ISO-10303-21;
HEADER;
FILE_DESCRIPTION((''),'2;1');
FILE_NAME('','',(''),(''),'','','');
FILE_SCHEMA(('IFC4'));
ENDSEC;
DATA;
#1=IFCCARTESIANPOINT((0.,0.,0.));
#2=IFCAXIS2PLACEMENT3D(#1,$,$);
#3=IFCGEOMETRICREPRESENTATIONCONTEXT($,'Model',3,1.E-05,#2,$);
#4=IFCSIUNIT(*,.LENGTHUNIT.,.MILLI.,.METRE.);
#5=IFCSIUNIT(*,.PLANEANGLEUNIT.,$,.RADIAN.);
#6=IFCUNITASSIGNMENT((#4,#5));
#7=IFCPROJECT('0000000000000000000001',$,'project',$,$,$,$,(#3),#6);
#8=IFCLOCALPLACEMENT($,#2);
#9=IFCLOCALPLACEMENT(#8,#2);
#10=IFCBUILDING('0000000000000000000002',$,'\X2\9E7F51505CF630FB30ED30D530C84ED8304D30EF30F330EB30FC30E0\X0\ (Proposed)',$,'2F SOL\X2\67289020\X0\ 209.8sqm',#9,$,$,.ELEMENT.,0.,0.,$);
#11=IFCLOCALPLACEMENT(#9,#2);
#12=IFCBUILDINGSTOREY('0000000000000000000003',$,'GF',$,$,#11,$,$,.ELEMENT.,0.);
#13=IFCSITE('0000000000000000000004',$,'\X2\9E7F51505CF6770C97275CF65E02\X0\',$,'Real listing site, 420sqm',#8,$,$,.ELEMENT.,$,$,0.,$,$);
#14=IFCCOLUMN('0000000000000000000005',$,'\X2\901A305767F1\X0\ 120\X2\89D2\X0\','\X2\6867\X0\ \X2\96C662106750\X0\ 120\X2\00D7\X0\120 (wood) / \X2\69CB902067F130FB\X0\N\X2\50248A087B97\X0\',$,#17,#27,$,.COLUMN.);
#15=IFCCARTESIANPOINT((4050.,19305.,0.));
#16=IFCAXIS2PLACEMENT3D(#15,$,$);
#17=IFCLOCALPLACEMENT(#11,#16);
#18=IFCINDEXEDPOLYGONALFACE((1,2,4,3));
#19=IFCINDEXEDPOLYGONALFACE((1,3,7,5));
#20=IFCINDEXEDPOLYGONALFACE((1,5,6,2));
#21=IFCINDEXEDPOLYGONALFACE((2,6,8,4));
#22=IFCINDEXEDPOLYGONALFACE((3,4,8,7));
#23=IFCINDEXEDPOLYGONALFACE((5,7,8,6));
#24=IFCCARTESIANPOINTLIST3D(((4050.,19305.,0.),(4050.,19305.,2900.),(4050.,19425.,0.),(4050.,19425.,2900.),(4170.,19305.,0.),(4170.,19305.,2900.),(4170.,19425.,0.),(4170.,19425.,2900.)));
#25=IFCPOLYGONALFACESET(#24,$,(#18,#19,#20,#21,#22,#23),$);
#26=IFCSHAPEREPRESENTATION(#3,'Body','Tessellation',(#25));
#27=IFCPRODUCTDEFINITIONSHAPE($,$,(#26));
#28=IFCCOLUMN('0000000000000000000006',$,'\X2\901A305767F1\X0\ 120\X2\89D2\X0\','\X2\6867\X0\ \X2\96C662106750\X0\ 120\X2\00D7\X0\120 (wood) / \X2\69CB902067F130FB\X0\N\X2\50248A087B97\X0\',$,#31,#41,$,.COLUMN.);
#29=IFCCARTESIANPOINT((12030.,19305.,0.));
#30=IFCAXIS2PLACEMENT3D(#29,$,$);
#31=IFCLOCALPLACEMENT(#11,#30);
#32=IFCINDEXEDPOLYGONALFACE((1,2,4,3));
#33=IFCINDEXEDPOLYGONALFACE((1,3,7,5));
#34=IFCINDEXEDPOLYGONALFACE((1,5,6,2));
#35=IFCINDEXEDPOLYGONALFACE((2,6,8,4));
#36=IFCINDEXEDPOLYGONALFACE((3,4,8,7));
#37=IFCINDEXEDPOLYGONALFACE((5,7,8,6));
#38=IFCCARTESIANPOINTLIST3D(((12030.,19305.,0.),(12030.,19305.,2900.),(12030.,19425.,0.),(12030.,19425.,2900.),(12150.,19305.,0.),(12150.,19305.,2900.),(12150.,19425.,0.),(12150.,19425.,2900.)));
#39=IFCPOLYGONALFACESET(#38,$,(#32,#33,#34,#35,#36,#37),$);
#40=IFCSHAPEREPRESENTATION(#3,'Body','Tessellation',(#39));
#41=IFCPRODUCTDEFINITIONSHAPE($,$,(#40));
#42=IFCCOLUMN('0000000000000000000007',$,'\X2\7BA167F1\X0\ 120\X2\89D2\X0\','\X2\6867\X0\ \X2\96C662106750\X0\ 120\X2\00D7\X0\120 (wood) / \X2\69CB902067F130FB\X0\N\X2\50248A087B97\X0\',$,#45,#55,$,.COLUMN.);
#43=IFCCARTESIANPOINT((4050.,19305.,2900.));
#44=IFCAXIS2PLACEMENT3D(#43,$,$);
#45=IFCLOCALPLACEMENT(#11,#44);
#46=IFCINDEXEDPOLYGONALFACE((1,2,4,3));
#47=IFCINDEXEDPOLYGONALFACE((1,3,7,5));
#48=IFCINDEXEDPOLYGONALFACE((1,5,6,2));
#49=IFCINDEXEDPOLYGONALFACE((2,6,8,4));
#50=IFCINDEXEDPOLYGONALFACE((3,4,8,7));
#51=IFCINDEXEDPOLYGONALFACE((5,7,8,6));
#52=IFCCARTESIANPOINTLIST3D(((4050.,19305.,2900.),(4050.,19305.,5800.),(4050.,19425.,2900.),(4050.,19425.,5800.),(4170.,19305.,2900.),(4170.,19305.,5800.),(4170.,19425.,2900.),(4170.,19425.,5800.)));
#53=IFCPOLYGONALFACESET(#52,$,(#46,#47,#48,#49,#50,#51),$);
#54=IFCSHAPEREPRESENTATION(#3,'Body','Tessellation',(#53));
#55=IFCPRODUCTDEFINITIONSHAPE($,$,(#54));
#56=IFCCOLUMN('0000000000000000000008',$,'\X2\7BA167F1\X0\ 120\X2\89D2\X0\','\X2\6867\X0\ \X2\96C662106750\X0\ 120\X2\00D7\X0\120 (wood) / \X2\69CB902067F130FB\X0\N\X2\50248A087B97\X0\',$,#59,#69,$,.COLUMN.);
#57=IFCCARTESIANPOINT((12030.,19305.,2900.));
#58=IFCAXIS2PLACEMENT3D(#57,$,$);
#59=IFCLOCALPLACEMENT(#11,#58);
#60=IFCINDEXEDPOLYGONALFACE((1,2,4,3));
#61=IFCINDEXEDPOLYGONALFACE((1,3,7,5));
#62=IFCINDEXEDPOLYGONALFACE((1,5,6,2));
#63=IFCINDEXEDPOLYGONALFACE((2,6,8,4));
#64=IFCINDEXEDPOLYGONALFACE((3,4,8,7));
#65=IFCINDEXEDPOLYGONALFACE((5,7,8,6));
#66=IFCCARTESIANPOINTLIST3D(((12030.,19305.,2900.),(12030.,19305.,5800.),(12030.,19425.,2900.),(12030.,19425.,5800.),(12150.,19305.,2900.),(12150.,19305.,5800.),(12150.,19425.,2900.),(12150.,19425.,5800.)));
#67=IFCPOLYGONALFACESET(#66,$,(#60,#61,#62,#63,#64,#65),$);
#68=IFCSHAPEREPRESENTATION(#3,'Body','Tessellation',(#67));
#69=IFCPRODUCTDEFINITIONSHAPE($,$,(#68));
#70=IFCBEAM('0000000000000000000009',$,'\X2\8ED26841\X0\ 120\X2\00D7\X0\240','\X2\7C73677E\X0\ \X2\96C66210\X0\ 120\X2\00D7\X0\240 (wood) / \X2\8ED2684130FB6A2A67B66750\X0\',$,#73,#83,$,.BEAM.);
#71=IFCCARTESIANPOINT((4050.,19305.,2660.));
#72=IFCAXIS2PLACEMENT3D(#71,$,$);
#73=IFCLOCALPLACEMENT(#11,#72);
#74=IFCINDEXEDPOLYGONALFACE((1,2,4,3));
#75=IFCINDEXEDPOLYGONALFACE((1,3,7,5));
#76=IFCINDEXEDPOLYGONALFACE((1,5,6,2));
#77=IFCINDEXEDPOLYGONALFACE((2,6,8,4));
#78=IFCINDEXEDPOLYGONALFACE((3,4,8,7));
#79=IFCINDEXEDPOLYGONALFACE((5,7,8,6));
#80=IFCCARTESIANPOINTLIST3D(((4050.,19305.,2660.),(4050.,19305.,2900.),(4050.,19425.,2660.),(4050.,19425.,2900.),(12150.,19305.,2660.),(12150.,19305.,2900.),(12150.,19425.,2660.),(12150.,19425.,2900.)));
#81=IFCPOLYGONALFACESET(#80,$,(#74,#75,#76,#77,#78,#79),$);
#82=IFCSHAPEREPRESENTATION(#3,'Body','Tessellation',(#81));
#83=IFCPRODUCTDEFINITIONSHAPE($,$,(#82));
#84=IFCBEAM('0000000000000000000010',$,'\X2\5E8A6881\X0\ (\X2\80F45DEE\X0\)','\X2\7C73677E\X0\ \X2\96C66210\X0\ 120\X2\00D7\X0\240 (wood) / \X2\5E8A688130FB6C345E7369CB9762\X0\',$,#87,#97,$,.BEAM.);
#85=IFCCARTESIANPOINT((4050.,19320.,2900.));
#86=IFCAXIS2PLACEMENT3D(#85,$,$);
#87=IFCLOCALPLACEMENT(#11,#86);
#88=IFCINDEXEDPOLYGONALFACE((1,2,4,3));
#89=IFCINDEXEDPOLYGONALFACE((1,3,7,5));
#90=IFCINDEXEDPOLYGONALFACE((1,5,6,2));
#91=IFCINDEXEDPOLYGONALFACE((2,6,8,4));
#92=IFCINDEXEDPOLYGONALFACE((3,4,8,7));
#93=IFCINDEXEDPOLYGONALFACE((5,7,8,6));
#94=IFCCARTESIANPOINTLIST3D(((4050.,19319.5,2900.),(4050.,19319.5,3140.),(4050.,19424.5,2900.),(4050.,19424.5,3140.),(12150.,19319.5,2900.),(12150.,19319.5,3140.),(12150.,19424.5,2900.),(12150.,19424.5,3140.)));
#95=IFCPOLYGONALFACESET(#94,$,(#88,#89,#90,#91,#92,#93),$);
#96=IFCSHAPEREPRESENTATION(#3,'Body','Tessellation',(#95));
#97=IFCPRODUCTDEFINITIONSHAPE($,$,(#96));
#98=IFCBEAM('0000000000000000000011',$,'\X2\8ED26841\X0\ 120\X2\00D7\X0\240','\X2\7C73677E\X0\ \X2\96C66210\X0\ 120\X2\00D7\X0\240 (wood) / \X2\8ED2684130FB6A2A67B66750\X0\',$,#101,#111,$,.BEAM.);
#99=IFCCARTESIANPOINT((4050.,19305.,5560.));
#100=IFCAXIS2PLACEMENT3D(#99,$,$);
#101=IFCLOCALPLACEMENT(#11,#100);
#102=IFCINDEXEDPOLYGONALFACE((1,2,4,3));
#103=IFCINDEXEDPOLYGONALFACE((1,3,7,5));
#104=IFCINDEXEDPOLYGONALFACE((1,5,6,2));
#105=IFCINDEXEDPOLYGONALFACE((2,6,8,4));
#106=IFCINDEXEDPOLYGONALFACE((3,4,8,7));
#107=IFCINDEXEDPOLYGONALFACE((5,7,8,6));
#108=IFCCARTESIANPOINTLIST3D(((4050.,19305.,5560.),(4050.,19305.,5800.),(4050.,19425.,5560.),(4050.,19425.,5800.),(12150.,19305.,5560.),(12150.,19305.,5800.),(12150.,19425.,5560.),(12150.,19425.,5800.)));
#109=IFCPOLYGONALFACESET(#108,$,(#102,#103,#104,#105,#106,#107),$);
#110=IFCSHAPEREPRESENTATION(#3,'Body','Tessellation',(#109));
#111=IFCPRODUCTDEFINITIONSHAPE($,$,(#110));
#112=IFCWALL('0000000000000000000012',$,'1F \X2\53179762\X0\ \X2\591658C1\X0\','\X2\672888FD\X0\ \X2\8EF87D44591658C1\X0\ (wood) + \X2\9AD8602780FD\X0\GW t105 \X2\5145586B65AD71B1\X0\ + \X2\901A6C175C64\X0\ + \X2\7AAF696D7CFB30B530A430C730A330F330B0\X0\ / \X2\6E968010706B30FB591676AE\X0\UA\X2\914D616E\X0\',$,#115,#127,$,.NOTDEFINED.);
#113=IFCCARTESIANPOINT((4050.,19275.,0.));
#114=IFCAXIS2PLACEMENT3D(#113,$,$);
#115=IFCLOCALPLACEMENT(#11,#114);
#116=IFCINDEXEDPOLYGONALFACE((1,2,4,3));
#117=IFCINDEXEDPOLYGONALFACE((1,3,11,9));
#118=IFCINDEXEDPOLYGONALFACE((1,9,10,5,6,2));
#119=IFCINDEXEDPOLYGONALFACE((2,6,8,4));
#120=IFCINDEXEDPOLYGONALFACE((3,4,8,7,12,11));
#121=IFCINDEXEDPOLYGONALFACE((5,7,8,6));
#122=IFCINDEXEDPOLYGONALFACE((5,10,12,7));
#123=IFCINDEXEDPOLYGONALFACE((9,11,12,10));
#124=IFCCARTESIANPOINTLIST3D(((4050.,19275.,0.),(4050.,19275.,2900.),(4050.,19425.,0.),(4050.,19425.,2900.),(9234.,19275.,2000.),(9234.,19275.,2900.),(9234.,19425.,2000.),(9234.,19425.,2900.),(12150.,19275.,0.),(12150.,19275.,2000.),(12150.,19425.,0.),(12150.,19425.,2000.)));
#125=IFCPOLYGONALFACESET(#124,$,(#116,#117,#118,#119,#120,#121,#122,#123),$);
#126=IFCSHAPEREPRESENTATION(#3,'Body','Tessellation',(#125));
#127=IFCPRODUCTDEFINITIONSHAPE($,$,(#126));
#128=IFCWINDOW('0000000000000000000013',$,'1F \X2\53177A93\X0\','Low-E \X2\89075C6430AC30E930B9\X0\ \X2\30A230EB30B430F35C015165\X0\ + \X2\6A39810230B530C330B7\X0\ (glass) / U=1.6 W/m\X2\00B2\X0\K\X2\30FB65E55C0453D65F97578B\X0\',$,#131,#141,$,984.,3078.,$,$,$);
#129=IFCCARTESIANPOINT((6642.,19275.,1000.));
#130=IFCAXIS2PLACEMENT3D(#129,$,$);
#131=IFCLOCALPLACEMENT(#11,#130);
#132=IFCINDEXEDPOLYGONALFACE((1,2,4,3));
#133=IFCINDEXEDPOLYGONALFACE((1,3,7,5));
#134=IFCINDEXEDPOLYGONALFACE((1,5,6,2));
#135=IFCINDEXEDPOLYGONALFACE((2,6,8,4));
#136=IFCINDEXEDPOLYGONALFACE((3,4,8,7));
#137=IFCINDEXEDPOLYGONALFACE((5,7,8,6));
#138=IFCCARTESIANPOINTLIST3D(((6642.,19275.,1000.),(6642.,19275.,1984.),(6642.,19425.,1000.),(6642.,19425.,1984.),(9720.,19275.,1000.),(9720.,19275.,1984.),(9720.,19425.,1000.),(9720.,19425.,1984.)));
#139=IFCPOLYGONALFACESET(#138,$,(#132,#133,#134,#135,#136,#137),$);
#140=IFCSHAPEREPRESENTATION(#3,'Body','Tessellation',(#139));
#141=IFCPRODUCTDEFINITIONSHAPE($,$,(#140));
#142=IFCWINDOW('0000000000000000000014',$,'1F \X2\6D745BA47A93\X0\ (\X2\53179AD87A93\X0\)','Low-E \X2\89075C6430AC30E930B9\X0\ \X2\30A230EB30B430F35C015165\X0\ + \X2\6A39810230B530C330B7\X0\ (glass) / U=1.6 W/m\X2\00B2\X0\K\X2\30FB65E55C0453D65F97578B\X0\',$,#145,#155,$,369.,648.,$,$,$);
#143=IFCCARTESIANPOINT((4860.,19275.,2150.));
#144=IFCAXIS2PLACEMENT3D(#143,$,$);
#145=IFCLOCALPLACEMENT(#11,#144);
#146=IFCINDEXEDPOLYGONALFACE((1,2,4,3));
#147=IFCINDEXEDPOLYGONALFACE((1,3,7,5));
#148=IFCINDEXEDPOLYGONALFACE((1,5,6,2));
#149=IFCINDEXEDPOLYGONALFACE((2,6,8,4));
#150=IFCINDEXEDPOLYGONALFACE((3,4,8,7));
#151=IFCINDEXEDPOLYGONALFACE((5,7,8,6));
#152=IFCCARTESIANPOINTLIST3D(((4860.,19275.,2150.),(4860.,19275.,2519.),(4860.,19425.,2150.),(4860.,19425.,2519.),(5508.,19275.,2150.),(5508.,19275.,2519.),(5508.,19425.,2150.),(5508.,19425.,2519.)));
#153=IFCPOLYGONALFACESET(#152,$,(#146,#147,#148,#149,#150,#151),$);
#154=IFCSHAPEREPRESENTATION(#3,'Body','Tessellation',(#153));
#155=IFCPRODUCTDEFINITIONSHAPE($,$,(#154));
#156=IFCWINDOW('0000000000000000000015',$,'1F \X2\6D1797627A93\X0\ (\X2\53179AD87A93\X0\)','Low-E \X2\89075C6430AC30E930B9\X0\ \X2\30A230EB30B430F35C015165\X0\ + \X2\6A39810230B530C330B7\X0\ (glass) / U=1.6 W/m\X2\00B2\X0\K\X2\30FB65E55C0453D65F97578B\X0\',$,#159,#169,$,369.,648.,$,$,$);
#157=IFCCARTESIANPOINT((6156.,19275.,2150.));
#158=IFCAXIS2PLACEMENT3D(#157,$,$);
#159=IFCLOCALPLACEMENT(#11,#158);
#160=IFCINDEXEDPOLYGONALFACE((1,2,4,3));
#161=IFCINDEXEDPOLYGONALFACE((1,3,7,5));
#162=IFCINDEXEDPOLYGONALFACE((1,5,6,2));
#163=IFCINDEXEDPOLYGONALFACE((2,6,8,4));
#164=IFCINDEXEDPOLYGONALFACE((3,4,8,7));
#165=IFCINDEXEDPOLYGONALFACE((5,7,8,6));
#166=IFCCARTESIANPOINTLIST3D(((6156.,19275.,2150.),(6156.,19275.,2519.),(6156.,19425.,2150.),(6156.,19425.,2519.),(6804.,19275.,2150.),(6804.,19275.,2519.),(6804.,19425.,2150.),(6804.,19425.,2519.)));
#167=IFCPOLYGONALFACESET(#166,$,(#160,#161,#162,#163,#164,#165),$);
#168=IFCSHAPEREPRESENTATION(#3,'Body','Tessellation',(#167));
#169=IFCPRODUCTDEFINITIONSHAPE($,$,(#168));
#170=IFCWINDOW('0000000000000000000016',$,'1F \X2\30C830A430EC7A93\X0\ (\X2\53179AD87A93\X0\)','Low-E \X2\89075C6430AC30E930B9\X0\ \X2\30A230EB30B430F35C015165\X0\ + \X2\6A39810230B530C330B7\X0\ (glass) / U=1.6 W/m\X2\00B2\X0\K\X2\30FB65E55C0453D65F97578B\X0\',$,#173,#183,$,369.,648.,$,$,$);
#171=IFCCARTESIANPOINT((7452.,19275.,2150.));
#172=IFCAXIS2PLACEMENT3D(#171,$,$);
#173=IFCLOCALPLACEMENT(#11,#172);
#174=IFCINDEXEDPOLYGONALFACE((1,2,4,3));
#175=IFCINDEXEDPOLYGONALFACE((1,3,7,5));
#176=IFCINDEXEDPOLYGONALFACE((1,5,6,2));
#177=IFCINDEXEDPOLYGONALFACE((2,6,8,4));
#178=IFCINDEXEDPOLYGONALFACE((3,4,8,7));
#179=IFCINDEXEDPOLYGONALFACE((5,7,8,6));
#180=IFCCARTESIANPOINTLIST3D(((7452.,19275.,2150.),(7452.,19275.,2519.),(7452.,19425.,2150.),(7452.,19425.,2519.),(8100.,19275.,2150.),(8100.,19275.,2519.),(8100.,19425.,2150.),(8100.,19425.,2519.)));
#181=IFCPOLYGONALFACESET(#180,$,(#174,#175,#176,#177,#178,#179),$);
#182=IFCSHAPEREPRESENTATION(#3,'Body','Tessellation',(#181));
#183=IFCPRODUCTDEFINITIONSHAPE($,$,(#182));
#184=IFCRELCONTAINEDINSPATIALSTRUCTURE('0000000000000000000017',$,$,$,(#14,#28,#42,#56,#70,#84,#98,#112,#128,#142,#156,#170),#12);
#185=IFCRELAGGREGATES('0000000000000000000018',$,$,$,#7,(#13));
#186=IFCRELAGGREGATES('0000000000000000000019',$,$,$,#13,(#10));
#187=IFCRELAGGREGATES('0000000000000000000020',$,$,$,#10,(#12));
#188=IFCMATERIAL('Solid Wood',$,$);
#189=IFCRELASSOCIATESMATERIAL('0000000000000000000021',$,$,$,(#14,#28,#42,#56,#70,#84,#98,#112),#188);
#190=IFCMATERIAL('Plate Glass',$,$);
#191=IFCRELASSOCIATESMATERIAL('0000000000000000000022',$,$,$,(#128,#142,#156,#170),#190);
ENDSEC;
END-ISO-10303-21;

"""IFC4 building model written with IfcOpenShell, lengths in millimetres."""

from ifc_helpers import new_model, si_unit, frame, frame_2d, origin, place, context, project, spatial, rectangle, extrude, material, element, fill, save


model = new_model("IFC4")

# Units and contexts
model_context = context("Model", 3, precision=1e-05, world=origin())
ifc_project = project(units=[si_unit("LENGTHUNIT", "METRE", prefix="MILLI"), si_unit("PLANEANGLEUNIT", "RADIAN")], contexts=[model_context])

# Site, building, storey
site_placement = place(None, origin())
site = spatial("IfcSite", under=ifc_project, at=site_placement, Name="鹿児島県霧島市", ObjectType="Real listing site, 420sqm", CompositionType="ELEMENT", RefElevation=0.0)
building_placement = place(site_placement, origin())
building = spatial("IfcBuilding", under=site, at=building_placement, Name="鹿児島・ロフト付きワンルーム (Proposed)", ObjectType="2F SOL木造 209.8sqm", CompositionType="ELEMENT", ElevationOfRefHeight=0.0, ElevationOfTerrain=0.0)
storey_placement = place(building_placement, origin())
storey = spatial("IfcBuildingStorey", under=building, at=storey_placement, Name="GF", CompositionType="ELEMENT", Elevation=0.0)

# Columns
ifc_material_1 = material(Name="Solid Wood")
column_1_placement = place(storey_placement, frame((4050.0, 19305.0, 0.0)))
element("IfcColumn", 1, at=column_1_placement, inside=storey, material=ifc_material_1, Name="通し柱 120角", Description="桧 集成材 120×120 (wood) / 構造柱・N値計算", PredefinedType="COLUMN", context=model_context, shape_type="SweptSolid", body=[
    extrude(rectangle(XDim=120.0, YDim=120.0, at=frame_2d((60.0, 60.0))), frame((4050.0, 19305.0, 0.0)), (0.0, 0.0, 1.0), 2900.0),
])
column_2_placement = place(storey_placement, frame((12030.0, 19305.0, 0.0)))
element("IfcColumn", 2, at=column_2_placement, inside=storey, material=ifc_material_1, Name="通し柱 120角", Description="桧 集成材 120×120 (wood) / 構造柱・N値計算", PredefinedType="COLUMN", context=model_context, shape_type="SweptSolid", body=[
    extrude(rectangle(XDim=120.0, YDim=120.0, at=frame_2d((60.0, 60.0))), frame((12030.0, 19305.0, 0.0)), (0.0, 0.0, 1.0), 2900.0),
])
column_3_placement = place(storey_placement, frame((4050.0, 19305.0, 2900.0)))
element("IfcColumn", 3, at=column_3_placement, inside=storey, material=ifc_material_1, Name="管柱 120角", Description="桧 集成材 120×120 (wood) / 構造柱・N値計算", PredefinedType="COLUMN", context=model_context, shape_type="SweptSolid", body=[
    extrude(rectangle(XDim=120.0, YDim=120.0, at=frame_2d((60.0, 60.0))), frame((4050.0, 19305.0, 2900.0)), (0.0, 0.0, 1.0), 2900.0),
])
column_4_placement = place(storey_placement, frame((12030.0, 19305.0, 2900.0)))
element("IfcColumn", 4, at=column_4_placement, inside=storey, material=ifc_material_1, Name="管柱 120角", Description="桧 集成材 120×120 (wood) / 構造柱・N値計算", PredefinedType="COLUMN", context=model_context, shape_type="SweptSolid", body=[
    extrude(rectangle(XDim=120.0, YDim=120.0, at=frame_2d((60.0, 60.0))), frame((12030.0, 19305.0, 2900.0)), (0.0, 0.0, 1.0), 2900.0),
])

# Beams
beam_1_placement = place(storey_placement, frame((4050.0, 19305.0, 2660.0)))
element("IfcBeam", 5, at=beam_1_placement, inside=storey, material=ifc_material_1, Name="軒桁 120×240", Description="米松 集成 120×240 (wood) / 軒桁・横架材", PredefinedType="BEAM", context=model_context, shape_type="SweptSolid", body=[
    extrude(rectangle(XDim=8100.0, YDim=120.0, at=frame_2d((4050.0, 60.0))), frame((4050.0, 19305.0, 2660.0)), (0.0, 0.0, 1.0), 240.0),
])
beam_2_placement = place(storey_placement, frame((4050.0, 19320.0, 2900.0)))
element("IfcBeam", 6, at=beam_2_placement, inside=storey, material=ifc_material_1, Name="床梁 (胴差)", Description="米松 集成 120×240 (wood) / 床梁・水平構面", PredefinedType="BEAM", context=model_context, shape_type="SweptSolid", body=[
    extrude(rectangle(XDim=8100.0, YDim=105.0, at=frame_2d((4050.0, 52.0))), frame((4050.0, 19320.0, 2900.0)), (0.0, 0.0, 1.0), 240.0),
])
beam_3_placement = place(storey_placement, frame((4050.0, 19305.0, 5560.0)))
element("IfcBeam", 7, at=beam_3_placement, inside=storey, material=ifc_material_1, Name="軒桁 120×240", Description="米松 集成 120×240 (wood) / 軒桁・横架材", PredefinedType="BEAM", context=model_context, shape_type="SweptSolid", body=[
    extrude(rectangle(XDim=8100.0, YDim=120.0, at=frame_2d((4050.0, 60.0))), frame((4050.0, 19305.0, 5560.0)), (0.0, 0.0, 1.0), 240.0),
])

# Wall, openings, windows
wall_1_placement = place(storey_placement, frame((4050.0, 19275.0, 0.0)))
wall_1 = element("IfcWall", 8, at=wall_1_placement, inside=storey, material=ifc_material_1, Name="1F 北面 外壁", Description="木製 軸組外壁 (wood) + 高性能GW t105 充填断熱 + 通気層 + 窯業系サイディング / 準耐火・外皮UA配慮", PredefinedType="NOTDEFINED", context=model_context, shape_type="SweptSolid", body=[
    extrude(rectangle(XDim=8100.0, YDim=150.0, at=frame_2d((4050.0, 75.0))), frame((4050.0, 19275.0, 0.0)), (0.0, 0.0, 1.0), 2900.0),
])
opening_1_placement = place(storey_placement, frame((6642.0, 19275.0, 1000.0)))
opening_1 = element("IfcOpeningElement", 9, at=opening_1_placement, cuts=wall_1, PredefinedType="NOTDEFINED", context=model_context, shape_type="SweptSolid", body=[
    extrude(rectangle(XDim=3078.0, YDim=150.0, at=frame_2d((1539.0, 75.0))), frame((6642.0, 19275.0, 1000.0)), (0.0, 0.0, 1.0), 984.0),
])
opening_2_placement = place(storey_placement, frame((4860.0, 19275.0, 2150.0)))
opening_2 = element("IfcOpeningElement", 10, at=opening_2_placement, cuts=wall_1, PredefinedType="NOTDEFINED", context=model_context, shape_type="SweptSolid", body=[
    extrude(rectangle(XDim=648.0, YDim=150.0, at=frame_2d((324.0, 75.0))), frame((4860.0, 19275.0, 2150.0)), (0.0, 0.0, 1.0), 369.0),
])
opening_3_placement = place(storey_placement, frame((6156.0, 19275.0, 2150.0)))
opening_3 = element("IfcOpeningElement", 11, at=opening_3_placement, cuts=wall_1, PredefinedType="NOTDEFINED", context=model_context, shape_type="SweptSolid", body=[
    extrude(rectangle(XDim=648.0, YDim=150.0, at=frame_2d((324.0, 75.0))), frame((6156.0, 19275.0, 2150.0)), (0.0, 0.0, 1.0), 369.0),
])
opening_4_placement = place(storey_placement, frame((7452.0, 19275.0, 2150.0)))
opening_4 = element("IfcOpeningElement", 12, at=opening_4_placement, cuts=wall_1, PredefinedType="NOTDEFINED", context=model_context, shape_type="SweptSolid", body=[
    extrude(rectangle(XDim=648.0, YDim=150.0, at=frame_2d((324.0, 75.0))), frame((7452.0, 19275.0, 2150.0)), (0.0, 0.0, 1.0), 369.0),
])
ifc_material_2 = material(Name="Plate Glass")
window_1_placement = place(storey_placement, frame((6642.0, 19275.0, 1000.0)))
window_1 = element("IfcWindow", 13, at=window_1_placement, inside=storey, material=ifc_material_2, Name="1F 北窓", Description="Low-E 複層ガラス アルゴン封入 + 樹脂サッシ (glass) / U=1.6 W/m²K・日射取得型", OverallHeight=984.0, OverallWidth=3078.0, context=model_context, shape_type="SweptSolid", body=[
    extrude(rectangle(XDim=3078.0, YDim=150.0, at=frame_2d((1539.0, 75.0))), frame((6642.0, 19275.0, 1000.0)), (0.0, 0.0, 1.0), 984.0),
])
fill(opening_1, window_1)
window_2_placement = place(storey_placement, frame((4860.0, 19275.0, 2150.0)))
window_2 = element("IfcWindow", 14, at=window_2_placement, inside=storey, material=ifc_material_2, Name="1F 浴室窓 (北高窓)", Description="Low-E 複層ガラス アルゴン封入 + 樹脂サッシ (glass) / U=1.6 W/m²K・日射取得型", OverallHeight=369.0, OverallWidth=648.0, context=model_context, shape_type="SweptSolid", body=[
    extrude(rectangle(XDim=648.0, YDim=150.0, at=frame_2d((324.0, 75.0))), frame((4860.0, 19275.0, 2150.0)), (0.0, 0.0, 1.0), 369.0),
])
fill(opening_2, window_2)
window_3_placement = place(storey_placement, frame((6156.0, 19275.0, 2150.0)))
window_3 = element("IfcWindow", 15, at=window_3_placement, inside=storey, material=ifc_material_2, Name="1F 洗面窓 (北高窓)", Description="Low-E 複層ガラス アルゴン封入 + 樹脂サッシ (glass) / U=1.6 W/m²K・日射取得型", OverallHeight=369.0, OverallWidth=648.0, context=model_context, shape_type="SweptSolid", body=[
    extrude(rectangle(XDim=648.0, YDim=150.0, at=frame_2d((324.0, 75.0))), frame((6156.0, 19275.0, 2150.0)), (0.0, 0.0, 1.0), 369.0),
])
fill(opening_3, window_3)
window_4_placement = place(storey_placement, frame((7452.0, 19275.0, 2150.0)))
window_4 = element("IfcWindow", 16, at=window_4_placement, inside=storey, material=ifc_material_2, Name="1F トイレ窓 (北高窓)", Description="Low-E 複層ガラス アルゴン封入 + 樹脂サッシ (glass) / U=1.6 W/m²K・日射取得型", OverallHeight=369.0, OverallWidth=648.0, context=model_context, shape_type="SweptSolid", body=[
    extrude(rectangle(XDim=648.0, YDim=150.0, at=frame_2d((324.0, 75.0))), frame((7452.0, 19275.0, 2150.0)), (0.0, 0.0, 1.0), 369.0),
])
fill(opening_4, window_4)

save(model, "model.ifc")
